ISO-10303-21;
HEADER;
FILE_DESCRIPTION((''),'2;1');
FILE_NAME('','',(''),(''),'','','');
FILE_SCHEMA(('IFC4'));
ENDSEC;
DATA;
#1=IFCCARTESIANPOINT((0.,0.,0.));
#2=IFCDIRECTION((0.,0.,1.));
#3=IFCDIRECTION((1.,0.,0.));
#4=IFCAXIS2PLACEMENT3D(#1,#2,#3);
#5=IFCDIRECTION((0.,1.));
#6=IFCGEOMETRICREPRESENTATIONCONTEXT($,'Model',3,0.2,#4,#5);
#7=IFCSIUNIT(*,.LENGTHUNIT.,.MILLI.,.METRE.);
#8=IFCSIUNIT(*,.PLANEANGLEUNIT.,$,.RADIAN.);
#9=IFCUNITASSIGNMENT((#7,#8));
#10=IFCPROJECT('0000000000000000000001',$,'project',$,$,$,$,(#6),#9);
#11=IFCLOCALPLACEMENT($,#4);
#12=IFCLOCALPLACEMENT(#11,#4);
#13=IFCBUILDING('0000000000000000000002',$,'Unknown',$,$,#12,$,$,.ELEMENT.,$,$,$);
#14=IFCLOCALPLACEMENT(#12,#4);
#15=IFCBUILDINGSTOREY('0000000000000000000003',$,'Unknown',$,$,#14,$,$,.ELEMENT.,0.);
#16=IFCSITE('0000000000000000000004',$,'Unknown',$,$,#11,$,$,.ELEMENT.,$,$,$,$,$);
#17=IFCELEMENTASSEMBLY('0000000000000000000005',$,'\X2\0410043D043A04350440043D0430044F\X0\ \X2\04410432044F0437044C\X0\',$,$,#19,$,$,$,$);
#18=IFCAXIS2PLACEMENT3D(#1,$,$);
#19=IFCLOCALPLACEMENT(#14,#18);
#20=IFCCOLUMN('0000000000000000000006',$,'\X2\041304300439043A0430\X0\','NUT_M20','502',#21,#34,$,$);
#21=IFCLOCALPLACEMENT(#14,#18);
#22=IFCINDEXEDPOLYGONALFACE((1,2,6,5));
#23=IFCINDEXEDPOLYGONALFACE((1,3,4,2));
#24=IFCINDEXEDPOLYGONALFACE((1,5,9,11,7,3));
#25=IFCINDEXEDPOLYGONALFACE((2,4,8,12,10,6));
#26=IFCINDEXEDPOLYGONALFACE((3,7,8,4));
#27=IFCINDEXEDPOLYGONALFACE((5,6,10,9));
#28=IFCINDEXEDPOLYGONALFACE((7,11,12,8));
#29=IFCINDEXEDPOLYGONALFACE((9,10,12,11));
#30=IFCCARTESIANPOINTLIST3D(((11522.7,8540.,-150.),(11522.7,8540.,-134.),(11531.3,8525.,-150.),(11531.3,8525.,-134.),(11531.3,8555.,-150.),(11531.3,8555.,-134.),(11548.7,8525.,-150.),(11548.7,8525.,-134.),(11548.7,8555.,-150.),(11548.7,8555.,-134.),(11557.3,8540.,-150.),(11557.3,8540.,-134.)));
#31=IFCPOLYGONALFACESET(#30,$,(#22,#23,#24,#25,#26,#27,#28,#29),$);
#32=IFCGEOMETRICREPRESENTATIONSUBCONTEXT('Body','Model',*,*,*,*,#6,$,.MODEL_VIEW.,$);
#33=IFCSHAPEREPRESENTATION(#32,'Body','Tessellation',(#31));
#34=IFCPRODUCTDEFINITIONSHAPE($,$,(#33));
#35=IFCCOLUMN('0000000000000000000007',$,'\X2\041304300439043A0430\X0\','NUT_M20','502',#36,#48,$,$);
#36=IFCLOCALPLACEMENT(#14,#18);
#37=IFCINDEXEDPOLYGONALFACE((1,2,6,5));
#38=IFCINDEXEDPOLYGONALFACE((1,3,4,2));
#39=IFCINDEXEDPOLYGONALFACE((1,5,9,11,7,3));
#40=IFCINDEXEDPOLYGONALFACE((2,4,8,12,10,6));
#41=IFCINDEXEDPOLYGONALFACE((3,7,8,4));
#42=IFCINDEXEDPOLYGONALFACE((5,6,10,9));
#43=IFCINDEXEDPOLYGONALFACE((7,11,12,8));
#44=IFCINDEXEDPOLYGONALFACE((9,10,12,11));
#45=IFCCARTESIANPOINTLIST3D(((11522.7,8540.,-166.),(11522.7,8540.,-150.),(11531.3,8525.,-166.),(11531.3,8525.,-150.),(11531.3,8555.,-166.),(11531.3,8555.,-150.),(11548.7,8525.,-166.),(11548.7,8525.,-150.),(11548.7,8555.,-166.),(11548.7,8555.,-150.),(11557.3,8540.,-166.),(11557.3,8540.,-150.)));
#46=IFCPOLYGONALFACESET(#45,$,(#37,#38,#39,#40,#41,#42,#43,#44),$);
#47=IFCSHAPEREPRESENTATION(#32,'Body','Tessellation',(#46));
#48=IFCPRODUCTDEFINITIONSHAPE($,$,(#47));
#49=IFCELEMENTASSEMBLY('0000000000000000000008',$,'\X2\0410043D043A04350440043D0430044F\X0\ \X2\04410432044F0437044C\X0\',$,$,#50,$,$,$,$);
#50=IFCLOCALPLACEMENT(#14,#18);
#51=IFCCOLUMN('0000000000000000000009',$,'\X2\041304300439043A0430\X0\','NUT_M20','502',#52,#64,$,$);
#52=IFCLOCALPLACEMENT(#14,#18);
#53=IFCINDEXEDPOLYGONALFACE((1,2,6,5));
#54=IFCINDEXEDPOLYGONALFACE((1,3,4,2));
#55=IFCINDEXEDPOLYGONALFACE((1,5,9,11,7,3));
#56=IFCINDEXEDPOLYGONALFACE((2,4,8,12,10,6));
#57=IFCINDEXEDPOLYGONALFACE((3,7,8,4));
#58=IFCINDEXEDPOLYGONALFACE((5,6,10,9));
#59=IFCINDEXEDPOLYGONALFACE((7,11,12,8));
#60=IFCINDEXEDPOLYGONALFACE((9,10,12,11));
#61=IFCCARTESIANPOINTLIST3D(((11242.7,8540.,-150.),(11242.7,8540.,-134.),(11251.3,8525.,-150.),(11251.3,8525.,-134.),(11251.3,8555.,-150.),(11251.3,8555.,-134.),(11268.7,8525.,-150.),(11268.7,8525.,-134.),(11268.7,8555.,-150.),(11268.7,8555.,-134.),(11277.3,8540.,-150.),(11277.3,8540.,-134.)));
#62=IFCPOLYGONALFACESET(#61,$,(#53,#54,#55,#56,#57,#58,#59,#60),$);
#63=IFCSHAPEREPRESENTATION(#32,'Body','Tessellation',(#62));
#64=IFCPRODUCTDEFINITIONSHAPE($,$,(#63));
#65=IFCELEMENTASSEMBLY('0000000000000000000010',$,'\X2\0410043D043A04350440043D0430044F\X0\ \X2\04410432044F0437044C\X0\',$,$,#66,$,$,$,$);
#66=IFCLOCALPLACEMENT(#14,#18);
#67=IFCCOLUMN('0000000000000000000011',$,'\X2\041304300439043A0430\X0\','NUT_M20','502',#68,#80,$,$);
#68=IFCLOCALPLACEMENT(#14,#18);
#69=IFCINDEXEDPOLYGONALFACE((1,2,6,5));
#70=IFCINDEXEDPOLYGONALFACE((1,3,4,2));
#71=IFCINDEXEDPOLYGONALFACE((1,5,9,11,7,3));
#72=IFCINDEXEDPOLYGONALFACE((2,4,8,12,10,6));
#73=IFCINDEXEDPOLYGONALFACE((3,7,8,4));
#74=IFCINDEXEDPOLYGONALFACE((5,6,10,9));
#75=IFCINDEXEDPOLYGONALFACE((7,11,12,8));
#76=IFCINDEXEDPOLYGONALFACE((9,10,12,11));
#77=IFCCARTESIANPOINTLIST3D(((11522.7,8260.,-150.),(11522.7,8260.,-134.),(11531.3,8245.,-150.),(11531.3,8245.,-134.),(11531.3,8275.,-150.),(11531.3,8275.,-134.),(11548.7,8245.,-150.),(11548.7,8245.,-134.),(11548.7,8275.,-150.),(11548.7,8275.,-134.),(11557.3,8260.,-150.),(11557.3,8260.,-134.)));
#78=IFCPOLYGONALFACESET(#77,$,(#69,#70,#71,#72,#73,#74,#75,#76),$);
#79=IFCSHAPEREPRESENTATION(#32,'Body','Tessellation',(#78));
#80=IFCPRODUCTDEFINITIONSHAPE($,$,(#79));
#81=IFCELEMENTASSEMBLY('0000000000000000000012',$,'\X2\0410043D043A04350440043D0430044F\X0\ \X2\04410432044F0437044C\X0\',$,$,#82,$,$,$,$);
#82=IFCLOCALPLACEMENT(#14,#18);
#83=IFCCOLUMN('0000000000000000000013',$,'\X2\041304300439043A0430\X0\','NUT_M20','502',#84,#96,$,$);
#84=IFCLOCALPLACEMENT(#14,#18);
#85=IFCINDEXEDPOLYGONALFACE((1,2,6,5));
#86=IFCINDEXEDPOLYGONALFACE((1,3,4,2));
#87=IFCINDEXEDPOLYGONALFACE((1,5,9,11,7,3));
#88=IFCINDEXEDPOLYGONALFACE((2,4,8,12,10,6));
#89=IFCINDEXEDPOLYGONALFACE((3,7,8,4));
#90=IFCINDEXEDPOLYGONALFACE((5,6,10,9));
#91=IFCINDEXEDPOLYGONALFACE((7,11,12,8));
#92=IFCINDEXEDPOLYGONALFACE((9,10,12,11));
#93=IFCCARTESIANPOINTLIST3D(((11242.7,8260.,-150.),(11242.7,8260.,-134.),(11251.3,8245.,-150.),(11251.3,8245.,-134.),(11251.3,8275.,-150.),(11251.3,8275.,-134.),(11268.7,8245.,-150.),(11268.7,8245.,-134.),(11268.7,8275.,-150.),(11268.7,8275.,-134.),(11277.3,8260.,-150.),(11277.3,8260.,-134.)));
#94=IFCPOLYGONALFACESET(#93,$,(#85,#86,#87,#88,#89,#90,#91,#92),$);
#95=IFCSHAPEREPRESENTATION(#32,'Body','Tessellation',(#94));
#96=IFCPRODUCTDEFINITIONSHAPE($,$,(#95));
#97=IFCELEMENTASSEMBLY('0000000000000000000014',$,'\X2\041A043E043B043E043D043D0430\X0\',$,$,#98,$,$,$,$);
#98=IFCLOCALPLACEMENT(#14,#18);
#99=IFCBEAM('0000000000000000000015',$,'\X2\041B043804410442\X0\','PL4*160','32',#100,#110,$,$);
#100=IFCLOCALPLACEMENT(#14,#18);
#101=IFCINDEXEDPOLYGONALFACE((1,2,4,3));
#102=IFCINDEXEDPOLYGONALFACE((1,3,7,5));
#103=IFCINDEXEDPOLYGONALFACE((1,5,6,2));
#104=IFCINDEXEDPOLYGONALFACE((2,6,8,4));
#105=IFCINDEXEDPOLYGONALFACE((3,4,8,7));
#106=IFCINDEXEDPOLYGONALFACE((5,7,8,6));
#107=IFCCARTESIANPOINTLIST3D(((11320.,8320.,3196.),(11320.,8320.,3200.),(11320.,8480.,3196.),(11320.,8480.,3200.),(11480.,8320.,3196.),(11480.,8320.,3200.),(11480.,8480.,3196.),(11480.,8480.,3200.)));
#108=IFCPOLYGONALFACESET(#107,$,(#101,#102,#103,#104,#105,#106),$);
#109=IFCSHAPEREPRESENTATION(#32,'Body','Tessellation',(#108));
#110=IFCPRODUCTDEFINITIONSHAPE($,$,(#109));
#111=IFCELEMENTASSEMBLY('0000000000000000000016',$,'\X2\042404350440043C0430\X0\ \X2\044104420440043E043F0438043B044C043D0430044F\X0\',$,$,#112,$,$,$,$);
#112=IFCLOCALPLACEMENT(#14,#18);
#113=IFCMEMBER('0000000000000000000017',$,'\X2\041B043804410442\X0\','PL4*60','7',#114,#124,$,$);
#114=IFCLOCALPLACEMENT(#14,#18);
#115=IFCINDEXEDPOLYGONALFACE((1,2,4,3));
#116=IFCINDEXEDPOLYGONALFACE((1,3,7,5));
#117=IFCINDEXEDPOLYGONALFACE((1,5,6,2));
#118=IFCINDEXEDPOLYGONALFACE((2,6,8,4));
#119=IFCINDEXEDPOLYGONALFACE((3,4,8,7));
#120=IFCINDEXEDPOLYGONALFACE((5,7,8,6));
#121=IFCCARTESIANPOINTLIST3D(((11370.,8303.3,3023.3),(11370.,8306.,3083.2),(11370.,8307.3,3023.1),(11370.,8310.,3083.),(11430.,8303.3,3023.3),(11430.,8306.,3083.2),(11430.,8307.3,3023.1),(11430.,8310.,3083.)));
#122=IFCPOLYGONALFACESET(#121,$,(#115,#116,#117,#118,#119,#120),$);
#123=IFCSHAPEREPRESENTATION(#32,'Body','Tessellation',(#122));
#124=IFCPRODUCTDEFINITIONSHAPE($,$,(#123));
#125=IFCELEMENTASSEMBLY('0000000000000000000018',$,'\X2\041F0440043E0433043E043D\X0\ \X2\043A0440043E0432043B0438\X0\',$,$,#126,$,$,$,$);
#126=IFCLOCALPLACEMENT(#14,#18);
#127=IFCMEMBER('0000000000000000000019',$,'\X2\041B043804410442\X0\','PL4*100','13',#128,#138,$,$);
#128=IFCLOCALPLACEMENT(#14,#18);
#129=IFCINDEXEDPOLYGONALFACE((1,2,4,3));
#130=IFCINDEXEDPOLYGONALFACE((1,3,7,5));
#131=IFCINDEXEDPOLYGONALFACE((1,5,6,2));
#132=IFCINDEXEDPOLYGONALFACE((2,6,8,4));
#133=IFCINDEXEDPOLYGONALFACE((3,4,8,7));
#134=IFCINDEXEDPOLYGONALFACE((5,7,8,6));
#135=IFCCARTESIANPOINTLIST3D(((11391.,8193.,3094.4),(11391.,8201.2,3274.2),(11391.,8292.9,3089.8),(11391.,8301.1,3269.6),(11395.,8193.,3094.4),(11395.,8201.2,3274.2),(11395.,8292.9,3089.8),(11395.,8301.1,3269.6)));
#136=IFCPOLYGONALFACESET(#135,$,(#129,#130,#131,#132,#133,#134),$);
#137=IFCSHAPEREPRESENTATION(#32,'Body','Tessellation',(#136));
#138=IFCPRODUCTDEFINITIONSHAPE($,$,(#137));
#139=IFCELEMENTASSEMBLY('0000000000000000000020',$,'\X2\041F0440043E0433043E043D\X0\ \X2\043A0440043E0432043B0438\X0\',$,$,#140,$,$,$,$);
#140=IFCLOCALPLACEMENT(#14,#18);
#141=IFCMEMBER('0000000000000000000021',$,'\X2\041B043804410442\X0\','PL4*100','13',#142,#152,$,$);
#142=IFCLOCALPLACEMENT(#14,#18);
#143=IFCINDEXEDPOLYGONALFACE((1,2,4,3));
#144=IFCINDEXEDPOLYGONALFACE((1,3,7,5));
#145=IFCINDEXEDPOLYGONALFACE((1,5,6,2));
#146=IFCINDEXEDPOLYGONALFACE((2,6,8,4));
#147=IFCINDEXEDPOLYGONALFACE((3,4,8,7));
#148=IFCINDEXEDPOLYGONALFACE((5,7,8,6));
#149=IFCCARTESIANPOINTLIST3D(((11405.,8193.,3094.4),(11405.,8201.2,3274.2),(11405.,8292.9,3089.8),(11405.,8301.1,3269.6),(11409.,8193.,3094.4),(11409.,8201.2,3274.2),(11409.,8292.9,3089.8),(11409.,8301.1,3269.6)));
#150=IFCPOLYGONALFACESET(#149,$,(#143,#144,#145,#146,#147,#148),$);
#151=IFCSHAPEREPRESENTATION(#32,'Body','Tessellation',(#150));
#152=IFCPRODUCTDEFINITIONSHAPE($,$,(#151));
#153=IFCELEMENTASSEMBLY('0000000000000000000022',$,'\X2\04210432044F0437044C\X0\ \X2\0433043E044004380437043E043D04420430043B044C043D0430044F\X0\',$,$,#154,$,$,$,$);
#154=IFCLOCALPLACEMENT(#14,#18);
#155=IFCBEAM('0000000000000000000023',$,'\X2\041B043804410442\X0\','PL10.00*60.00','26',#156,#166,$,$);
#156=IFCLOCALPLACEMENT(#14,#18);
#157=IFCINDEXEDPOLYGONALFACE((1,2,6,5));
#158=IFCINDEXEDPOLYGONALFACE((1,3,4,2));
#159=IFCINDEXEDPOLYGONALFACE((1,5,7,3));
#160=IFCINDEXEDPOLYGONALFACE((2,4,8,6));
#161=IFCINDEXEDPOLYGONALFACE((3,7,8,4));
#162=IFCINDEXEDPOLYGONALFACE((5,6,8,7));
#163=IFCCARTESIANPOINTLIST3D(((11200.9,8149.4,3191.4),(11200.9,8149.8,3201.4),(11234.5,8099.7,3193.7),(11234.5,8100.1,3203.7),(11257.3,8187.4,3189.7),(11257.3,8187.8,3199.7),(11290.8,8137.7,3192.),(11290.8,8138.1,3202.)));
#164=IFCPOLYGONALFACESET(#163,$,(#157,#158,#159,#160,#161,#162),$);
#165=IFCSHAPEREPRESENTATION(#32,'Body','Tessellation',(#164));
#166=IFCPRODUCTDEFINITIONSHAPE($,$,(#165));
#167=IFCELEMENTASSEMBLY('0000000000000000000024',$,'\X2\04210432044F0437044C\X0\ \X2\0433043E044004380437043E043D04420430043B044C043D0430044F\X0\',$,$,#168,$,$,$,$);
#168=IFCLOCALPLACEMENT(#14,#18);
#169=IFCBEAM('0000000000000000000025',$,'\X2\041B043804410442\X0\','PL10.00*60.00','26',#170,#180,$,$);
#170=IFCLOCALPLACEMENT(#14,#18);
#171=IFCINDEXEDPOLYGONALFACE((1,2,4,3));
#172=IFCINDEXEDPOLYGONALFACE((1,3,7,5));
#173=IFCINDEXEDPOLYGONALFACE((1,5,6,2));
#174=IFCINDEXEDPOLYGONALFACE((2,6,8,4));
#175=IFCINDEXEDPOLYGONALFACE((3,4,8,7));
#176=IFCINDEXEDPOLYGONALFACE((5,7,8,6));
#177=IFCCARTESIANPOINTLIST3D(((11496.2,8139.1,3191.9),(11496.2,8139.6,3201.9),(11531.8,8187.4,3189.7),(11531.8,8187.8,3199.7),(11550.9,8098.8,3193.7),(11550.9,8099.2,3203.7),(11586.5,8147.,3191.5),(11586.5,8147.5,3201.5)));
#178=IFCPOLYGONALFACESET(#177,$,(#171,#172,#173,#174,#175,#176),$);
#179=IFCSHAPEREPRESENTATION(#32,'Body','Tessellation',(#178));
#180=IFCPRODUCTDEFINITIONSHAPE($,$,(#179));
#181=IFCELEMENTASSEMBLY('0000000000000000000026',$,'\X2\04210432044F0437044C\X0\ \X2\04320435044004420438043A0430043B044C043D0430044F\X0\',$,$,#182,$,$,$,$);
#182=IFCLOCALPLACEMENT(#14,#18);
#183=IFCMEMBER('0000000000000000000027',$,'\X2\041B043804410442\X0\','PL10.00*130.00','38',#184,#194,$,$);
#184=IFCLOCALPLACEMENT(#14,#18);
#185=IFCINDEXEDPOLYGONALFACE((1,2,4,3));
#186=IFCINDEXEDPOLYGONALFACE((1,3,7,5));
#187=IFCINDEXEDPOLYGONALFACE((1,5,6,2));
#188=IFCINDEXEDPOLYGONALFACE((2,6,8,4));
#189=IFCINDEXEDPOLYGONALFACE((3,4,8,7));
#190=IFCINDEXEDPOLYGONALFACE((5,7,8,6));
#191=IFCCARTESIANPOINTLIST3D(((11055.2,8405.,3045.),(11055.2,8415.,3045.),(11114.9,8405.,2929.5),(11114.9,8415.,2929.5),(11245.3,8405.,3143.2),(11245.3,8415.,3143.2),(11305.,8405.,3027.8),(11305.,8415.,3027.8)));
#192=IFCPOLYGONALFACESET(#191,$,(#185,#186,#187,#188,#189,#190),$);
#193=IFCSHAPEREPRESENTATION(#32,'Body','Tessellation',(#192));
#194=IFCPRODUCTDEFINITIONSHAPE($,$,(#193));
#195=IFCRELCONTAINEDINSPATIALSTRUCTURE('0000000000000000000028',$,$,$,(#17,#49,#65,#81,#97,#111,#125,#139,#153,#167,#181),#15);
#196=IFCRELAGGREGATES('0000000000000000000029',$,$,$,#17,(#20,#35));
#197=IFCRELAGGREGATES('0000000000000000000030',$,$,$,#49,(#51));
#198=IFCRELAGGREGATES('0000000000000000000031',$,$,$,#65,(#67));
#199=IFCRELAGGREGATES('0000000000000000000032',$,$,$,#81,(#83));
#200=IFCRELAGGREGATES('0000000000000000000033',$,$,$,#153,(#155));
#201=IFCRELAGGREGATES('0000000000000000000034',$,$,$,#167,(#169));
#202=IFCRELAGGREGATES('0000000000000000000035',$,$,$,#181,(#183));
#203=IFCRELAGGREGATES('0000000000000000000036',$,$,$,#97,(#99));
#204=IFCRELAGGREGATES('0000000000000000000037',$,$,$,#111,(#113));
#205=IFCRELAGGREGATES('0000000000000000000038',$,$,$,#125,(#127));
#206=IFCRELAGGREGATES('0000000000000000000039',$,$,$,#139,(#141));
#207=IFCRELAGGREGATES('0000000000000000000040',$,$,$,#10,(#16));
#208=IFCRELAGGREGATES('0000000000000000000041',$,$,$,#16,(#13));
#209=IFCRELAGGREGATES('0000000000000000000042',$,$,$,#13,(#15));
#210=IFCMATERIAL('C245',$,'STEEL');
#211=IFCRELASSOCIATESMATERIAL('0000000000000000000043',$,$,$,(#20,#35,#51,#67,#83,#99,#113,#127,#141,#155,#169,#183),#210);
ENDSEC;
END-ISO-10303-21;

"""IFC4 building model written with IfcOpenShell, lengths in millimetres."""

from ifc_helpers import new_model, si_unit, direction, frame, origin_with_axes, place, context, subcontext, project, spatial, line, indexed_curve, outline, extrude, material, element, aggregate, save


model = new_model("IFC4")

# Units and contexts
model_context = context("Model", 3, precision=0.2, world=origin_with_axes(), true_north=direction((0.0, 1.0)))
body_context = subcontext(model_context, "Body", "Model", "MODEL_VIEW")
ifc_project = project(units=[si_unit("LENGTHUNIT", "METRE", prefix="MILLI"), si_unit("PLANEANGLEUNIT", "RADIAN")], contexts=[model_context])

# Site, building, storey
site_placement = place(None, origin_with_axes())
site = spatial("IfcSite", under=ifc_project, at=site_placement, Name="Unknown", CompositionType="ELEMENT")
building_placement = place(site_placement, origin_with_axes())
building = spatial("IfcBuilding", under=site, at=building_placement, Name="Unknown", CompositionType="ELEMENT")
storey_placement = place(building_placement, origin_with_axes())
storey = spatial("IfcBuildingStorey", under=building, at=storey_placement, Name="Unknown", CompositionType="ELEMENT", Elevation=0.0)

# Element assembly, columns
assembly_1_placement = place(storey_placement, frame((11540.0, 8540.0, -125.0), z_axis=(-1.0, 0.0, 0.0), x_axis=(0.0, 0.0, -1.0)))
assembly_1 = element("IfcElementAssembly", 1, at=assembly_1_placement, inside=storey, Name="Анкерная связь")
ifc_material_1 = material(Name="C245", Category="STEEL")
column_1_placement = place(assembly_1_placement, frame((9.0, 0.0, 0.0), z_axis=(0.0, 0.0, -1.0), x_axis=(1.0, 0.0, 0.0)))
column_1 = element("IfcColumn", 2, at=column_1_placement, material=ifc_material_1, Name="Гайка", Description="NUT_M20", ObjectType="502", context=body_context, shape_type="SolidModel", body=[
    extrude(outline(indexed_curve([(8.7, -15.0), (17.3, 0.0), (8.7, 15.0), (-8.7, 15.0), (-17.3, 0.0), (-8.7, -15.0)], segments=[line(1, 2, 3, 4, 5, 6, 1)])), frame((0.0, 0.0, 0.0), z_axis=(-1.0, 0.0, 0.0), x_axis=(0.0, 0.0, 1.0)), (0.0, 0.0, -1.0), 16.0),
])
column_2_placement = place(assembly_1_placement, frame((25.0, 0.0, 0.0), z_axis=(0.0, 0.0, -1.0), x_axis=(1.0, 0.0, 0.0)))
column_2 = element("IfcColumn", 3, at=column_2_placement, material=ifc_material_1, Name="Гайка", Description="NUT_M20", ObjectType="502", context=body_context, shape_type="SolidModel", body=[
    extrude(outline(indexed_curve([(8.7, -15.0), (17.3, 0.0), (8.7, 15.0), (-8.7, 15.0), (-17.3, 0.0), (-8.7, -15.0)], segments=[line(1, 2, 3, 4, 5, 6, 1)])), frame((0.0, 0.0, 0.0), z_axis=(-1.0, 0.0, 0.0), x_axis=(0.0, 0.0, 1.0)), (0.0, 0.0, -1.0), 16.0),
])
aggregate(assembly_1, [column_1, column_2])

# Element assemblies, columns
assembly_2_placement = place(storey_placement, frame((11260.0, 8540.0, -125.0), z_axis=(1.0, 0.0, 0.0), x_axis=(0.0, 0.0, -1.0)))
assembly_2 = element("IfcElementAssembly", 4, at=assembly_2_placement, inside=storey, Name="Анкерная связь")
column_3_placement = place(assembly_2_placement, frame((9.0, 0.0, 0.0), z_axis=(0.0, 0.0, -1.0), x_axis=(1.0, 0.0, 0.0)))
column_3 = element("IfcColumn", 5, at=column_3_placement, material=ifc_material_1, Name="Гайка", Description="NUT_M20", ObjectType="502", context=body_context, shape_type="SolidModel", body=[
    extrude(outline(indexed_curve([(8.7, -15.0), (17.3, 0.0), (8.7, 15.0), (-8.7, 15.0), (-17.3, 0.0), (-8.7, -15.0)], segments=[line(1, 2, 3, 4, 5, 6, 1)])), frame((0.0, 0.0, 0.0), z_axis=(-1.0, 0.0, 0.0), x_axis=(0.0, 0.0, 1.0)), (0.0, 0.0, -1.0), 16.0),
])
assembly_3_placement = place(storey_placement, frame((11540.0, 8260.0, -125.0), z_axis=(1.0, 0.0, 0.0), x_axis=(0.0, 0.0, -1.0)))
assembly_3 = element("IfcElementAssembly", 6, at=assembly_3_placement, inside=storey, Name="Анкерная связь")
column_4_placement = place(assembly_3_placement, frame((9.0, 0.0, 0.0), z_axis=(0.0, 0.0, 1.0), x_axis=(1.0, 0.0, 0.0)))
column_4 = element("IfcColumn", 7, at=column_4_placement, material=ifc_material_1, Name="Гайка", Description="NUT_M20", ObjectType="502", context=body_context, shape_type="SolidModel", body=[
    extrude(outline(indexed_curve([(8.7, -15.0), (17.3, 0.0), (8.7, 15.0), (-8.7, 15.0), (-17.3, 0.0), (-8.7, -15.0)], segments=[line(1, 2, 3, 4, 5, 6, 1)])), frame((0.0, 0.0, 0.0), z_axis=(-1.0, 0.0, 0.0), x_axis=(0.0, 0.0, 1.0)), (0.0, 0.0, -1.0), 16.0),
])
assembly_4_placement = place(storey_placement, frame((11260.0, 8260.0, -125.0), z_axis=(-1.0, 0.0, 0.0), x_axis=(0.0, 0.0, -1.0)))
assembly_4 = element("IfcElementAssembly", 8, at=assembly_4_placement, inside=storey, Name="Анкерная связь")
column_5_placement = place(assembly_4_placement, frame((9.0, 0.0, 0.0), z_axis=(0.0, 0.0, 1.0), x_axis=(1.0, 0.0, 0.0)))
column_5 = element("IfcColumn", 9, at=column_5_placement, material=ifc_material_1, Name="Гайка", Description="NUT_M20", ObjectType="502", context=body_context, shape_type="SolidModel", body=[
    extrude(outline(indexed_curve([(8.7, -15.0), (17.3, 0.0), (8.7, 15.0), (-8.7, 15.0), (-17.3, 0.0), (-8.7, -15.0)], segments=[line(1, 2, 3, 4, 5, 6, 1)])), frame((0.0, 0.0, 0.0), z_axis=(-1.0, 0.0, 0.0), x_axis=(0.0, 0.0, 1.0)), (0.0, 0.0, -1.0), 16.0),
])

# Element assembly, beam
assembly_5_placement = place(storey_placement, frame((11400.0, 8400.0, -40.0), z_axis=(-1.0, 0.0, 0.0), x_axis=(0.0, 0.0, 1.0)))
assembly_5 = element("IfcElementAssembly", 10, at=assembly_5_placement, inside=storey, Name="Колонна")
beam_1_placement = place(assembly_5_placement, frame((3238.0, -80.0, 0.0), z_axis=(-1.0, 0.0, 0.0), x_axis=(0.0, 1.0, 0.0)))
beam_1 = element("IfcBeam", 11, at=beam_1_placement, material=ifc_material_1, Name="Лист", Description="PL4*160", ObjectType="32", context=body_context, shape_type="SolidModel", body=[
    extrude(outline(indexed_curve([(-2.0, -80.0), (2.0, -80.0), (2.0, 80.0), (-2.0, 80.0)], segments=[line(1, 2, 3, 4, 1)])), frame((0.0, 0.0, 0.0), z_axis=(-1.0, 0.0, 0.0), x_axis=(0.0, 0.0, 1.0)), (0.0, 0.0, -1.0), 160.0),
])

# Element assembly, member
assembly_6_placement = place(storey_placement, frame((11400.0, 88.6, 3426.7), z_axis=(1.0, 0.0, 0.0), x_axis=(0.0, 0.998969, -0.045408)))
assembly_6 = element("IfcElementAssembly", 12, at=assembly_6_placement, inside=storey, Name="Ферма стропильная")
member_1_placement = place(assembly_6_placement, frame((8226.5, -30.0, 0.0), z_axis=(-1.0, 0.0, 0.0), x_axis=(0.0, 1.0, 0.0)))
member_1 = element("IfcMember", 13, at=member_1_placement, material=ifc_material_1, Name="Лист", Description="PL4*60", ObjectType="7", context=body_context, shape_type="SolidModel", body=[
    extrude(outline(indexed_curve([(-2.0, -30.0), (2.0, -30.0), (2.0, 30.0), (-2.0, 30.0)], segments=[line(1, 2, 3, 4, 1)])), frame((0.0, 0.0, 0.0), z_axis=(-1.0, 0.0, 0.0), x_axis=(0.0, 0.0, 1.0)), (0.0, 0.0, -1.0), 60.0),
])

# Element assembly, member
assembly_7_placement = place(storey_placement, frame((5405.0, 8247.1, 3182.0), z_axis=(0.0, -0.998969, 0.045408), x_axis=(1.0, 0.0, 0.0)))
assembly_7 = element("IfcElementAssembly", 14, at=assembly_7_placement, inside=storey, Name="Прогон кровли")
member_2_placement = place(assembly_7_placement, frame((5988.0, -90.0, 0.0), z_axis=(-1.0, 0.0, 0.0), x_axis=(0.0, 1.0, 0.0)))
member_2 = element("IfcMember", 15, at=member_2_placement, material=ifc_material_1, Name="Лист", Description="PL4*100", ObjectType="13", context=body_context, shape_type="SolidModel", body=[
    extrude(outline(indexed_curve([(-2.0, -50.0), (2.0, -50.0), (2.0, 50.0), (-2.0, 50.0)], segments=[line(1, 2, 3, 4, 1)])), frame((0.0, 0.0, 0.0), z_axis=(-1.0, 0.0, 0.0), x_axis=(0.0, 0.0, 1.0)), (0.0, 0.0, -1.0), 180.0),
])

aggregate(assembly_2, [column_3])
aggregate(assembly_3, [column_4])
aggregate(assembly_4, [column_5])

# Element assembly, member
assembly_8_placement = place(storey_placement, frame((17395.0, 8247.1, 3182.0), z_axis=(0.0, 0.998969, -0.045408), x_axis=(-1.0, 0.0, 0.0)))
assembly_8 = element("IfcElementAssembly", 16, at=assembly_8_placement, inside=storey, Name="Прогон кровли")
member_3_placement = place(assembly_8_placement, frame((5988.0, -90.0, 0.0), z_axis=(-1.0, 0.0, 0.0), x_axis=(0.0, 1.0, 0.0)))
member_3 = element("IfcMember", 17, at=member_3_placement, material=ifc_material_1, Name="Лист", Description="PL4*100", ObjectType="13", context=body_context, shape_type="SolidModel", body=[
    extrude(outline(indexed_curve([(-2.0, -50.0), (2.0, -50.0), (2.0, 50.0), (-2.0, 50.0)], segments=[line(1, 2, 3, 4, 1)])), frame((0.0, 0.0, 0.0), z_axis=(-1.0, 0.0, 0.0), x_axis=(0.0, 0.0, 1.0)), (0.0, 0.0, -1.0), 180.0),
])

# Element assemblies, beams
assembly_9_placement = place(storey_placement, frame((11400.0, 8247.5, 3192.0), z_axis=(-0.558918, 0.828367, -0.037653), x_axis=(-0.829223, -0.558342, 0.025379)))
assembly_9 = element("IfcElementAssembly", 18, at=assembly_9_placement, inside=storey, Name="Связь горизонтальная")
beam_2_placement = place(assembly_9_placement, frame((151.9, 0.0, 0.0), z_axis=(0.0, -1.0, 0.0), x_axis=(1.0, 0.0, 0.0)))
beam_2 = element("IfcBeam", 19, at=beam_2_placement, material=ifc_material_1, Name="Лист", Description="PL10.00*60.00", ObjectType="26", context=body_context, shape_type="SolidModel", body=[
    extrude(outline(indexed_curve([(-5.0, -30.0), (5.0, -30.0), (5.0, 30.0), (-5.0, 30.0)], segments=[line(1, 2, 3, 4, 1)])), frame((0.0, 0.0, 0.0), z_axis=(-1.0, 0.0, 0.0), x_axis=(0.0, 0.0, 1.0)), (0.0, 0.0, -1.0), 68.0),
])
aggregate(assembly_9, [beam_2])
assembly_10_placement = place(storey_placement, frame((11400.0, 8247.5, 3192.0), z_axis=(-0.593795, -0.803786, 0.036536), x_axis=(0.804616, -0.593183, 0.026963)))
assembly_10 = element("IfcElementAssembly", 20, at=assembly_10_placement, inside=storey, Name="Связь горизонтальная")
beam_3_placement = place(assembly_10_placement, frame((141.7, 0.0, 0.0), z_axis=(0.0, 1.0, 0.0), x_axis=(1.0, 0.0, 0.0)))
beam_3 = element("IfcBeam", 21, at=beam_3_placement, material=ifc_material_1, Name="Лист", Description="PL10.00*60.00", ObjectType="26", context=body_context, shape_type="SolidModel", body=[
    extrude(outline(indexed_curve([(-5.0, -30.0), (5.0, -30.0), (5.0, 30.0), (-5.0, 30.0)], segments=[line(1, 2, 3, 4, 1)])), frame((0.0, 0.0, 0.0), z_axis=(-1.0, 0.0, 0.0), x_axis=(0.0, 0.0, 1.0)), (0.0, 0.0, -1.0), 68.0),
])
aggregate(assembly_10, [beam_3])

# Element assembly, member
assembly_11_placement = place(storey_placement, frame((5400.0, 8410.0, 50.0), z_axis=(0.0, -1.0, 0.0), x_axis=(0.888426, 0.0, 0.45902)))
assembly_11 = element("IfcElementAssembly", 22, at=assembly_11_placement, inside=storey, Name="Связь вертикальная")
member_4_placement = place(assembly_11_placement, frame((6613.0, 0.0, 0.0), z_axis=(0.0, 0.0, 1.0), x_axis=(-1.0, 0.0, 0.0)))
member_4 = element("IfcMember", 23, at=member_4_placement, material=ifc_material_1, Name="Лист", Description="PL10.00*130.00", ObjectType="38", context=body_context, shape_type="SolidModel", body=[
    extrude(outline(indexed_curve([(-5.0, -65.0), (5.0, -65.0), (5.0, 65.0), (-5.0, 65.0)], segments=[line(1, 2, 3, 4, 1)])), frame((0.0, 0.0, 0.0), z_axis=(-1.0, 0.0, 0.0), x_axis=(0.0, 0.0, 1.0)), (0.0, 0.0, -1.0), 214.0),
])
aggregate(assembly_11, [member_4])

aggregate(assembly_5, [beam_1])
aggregate(assembly_6, [member_1])
aggregate(assembly_7, [member_2])
aggregate(assembly_8, [member_3])

save(model, "model.ifc")
